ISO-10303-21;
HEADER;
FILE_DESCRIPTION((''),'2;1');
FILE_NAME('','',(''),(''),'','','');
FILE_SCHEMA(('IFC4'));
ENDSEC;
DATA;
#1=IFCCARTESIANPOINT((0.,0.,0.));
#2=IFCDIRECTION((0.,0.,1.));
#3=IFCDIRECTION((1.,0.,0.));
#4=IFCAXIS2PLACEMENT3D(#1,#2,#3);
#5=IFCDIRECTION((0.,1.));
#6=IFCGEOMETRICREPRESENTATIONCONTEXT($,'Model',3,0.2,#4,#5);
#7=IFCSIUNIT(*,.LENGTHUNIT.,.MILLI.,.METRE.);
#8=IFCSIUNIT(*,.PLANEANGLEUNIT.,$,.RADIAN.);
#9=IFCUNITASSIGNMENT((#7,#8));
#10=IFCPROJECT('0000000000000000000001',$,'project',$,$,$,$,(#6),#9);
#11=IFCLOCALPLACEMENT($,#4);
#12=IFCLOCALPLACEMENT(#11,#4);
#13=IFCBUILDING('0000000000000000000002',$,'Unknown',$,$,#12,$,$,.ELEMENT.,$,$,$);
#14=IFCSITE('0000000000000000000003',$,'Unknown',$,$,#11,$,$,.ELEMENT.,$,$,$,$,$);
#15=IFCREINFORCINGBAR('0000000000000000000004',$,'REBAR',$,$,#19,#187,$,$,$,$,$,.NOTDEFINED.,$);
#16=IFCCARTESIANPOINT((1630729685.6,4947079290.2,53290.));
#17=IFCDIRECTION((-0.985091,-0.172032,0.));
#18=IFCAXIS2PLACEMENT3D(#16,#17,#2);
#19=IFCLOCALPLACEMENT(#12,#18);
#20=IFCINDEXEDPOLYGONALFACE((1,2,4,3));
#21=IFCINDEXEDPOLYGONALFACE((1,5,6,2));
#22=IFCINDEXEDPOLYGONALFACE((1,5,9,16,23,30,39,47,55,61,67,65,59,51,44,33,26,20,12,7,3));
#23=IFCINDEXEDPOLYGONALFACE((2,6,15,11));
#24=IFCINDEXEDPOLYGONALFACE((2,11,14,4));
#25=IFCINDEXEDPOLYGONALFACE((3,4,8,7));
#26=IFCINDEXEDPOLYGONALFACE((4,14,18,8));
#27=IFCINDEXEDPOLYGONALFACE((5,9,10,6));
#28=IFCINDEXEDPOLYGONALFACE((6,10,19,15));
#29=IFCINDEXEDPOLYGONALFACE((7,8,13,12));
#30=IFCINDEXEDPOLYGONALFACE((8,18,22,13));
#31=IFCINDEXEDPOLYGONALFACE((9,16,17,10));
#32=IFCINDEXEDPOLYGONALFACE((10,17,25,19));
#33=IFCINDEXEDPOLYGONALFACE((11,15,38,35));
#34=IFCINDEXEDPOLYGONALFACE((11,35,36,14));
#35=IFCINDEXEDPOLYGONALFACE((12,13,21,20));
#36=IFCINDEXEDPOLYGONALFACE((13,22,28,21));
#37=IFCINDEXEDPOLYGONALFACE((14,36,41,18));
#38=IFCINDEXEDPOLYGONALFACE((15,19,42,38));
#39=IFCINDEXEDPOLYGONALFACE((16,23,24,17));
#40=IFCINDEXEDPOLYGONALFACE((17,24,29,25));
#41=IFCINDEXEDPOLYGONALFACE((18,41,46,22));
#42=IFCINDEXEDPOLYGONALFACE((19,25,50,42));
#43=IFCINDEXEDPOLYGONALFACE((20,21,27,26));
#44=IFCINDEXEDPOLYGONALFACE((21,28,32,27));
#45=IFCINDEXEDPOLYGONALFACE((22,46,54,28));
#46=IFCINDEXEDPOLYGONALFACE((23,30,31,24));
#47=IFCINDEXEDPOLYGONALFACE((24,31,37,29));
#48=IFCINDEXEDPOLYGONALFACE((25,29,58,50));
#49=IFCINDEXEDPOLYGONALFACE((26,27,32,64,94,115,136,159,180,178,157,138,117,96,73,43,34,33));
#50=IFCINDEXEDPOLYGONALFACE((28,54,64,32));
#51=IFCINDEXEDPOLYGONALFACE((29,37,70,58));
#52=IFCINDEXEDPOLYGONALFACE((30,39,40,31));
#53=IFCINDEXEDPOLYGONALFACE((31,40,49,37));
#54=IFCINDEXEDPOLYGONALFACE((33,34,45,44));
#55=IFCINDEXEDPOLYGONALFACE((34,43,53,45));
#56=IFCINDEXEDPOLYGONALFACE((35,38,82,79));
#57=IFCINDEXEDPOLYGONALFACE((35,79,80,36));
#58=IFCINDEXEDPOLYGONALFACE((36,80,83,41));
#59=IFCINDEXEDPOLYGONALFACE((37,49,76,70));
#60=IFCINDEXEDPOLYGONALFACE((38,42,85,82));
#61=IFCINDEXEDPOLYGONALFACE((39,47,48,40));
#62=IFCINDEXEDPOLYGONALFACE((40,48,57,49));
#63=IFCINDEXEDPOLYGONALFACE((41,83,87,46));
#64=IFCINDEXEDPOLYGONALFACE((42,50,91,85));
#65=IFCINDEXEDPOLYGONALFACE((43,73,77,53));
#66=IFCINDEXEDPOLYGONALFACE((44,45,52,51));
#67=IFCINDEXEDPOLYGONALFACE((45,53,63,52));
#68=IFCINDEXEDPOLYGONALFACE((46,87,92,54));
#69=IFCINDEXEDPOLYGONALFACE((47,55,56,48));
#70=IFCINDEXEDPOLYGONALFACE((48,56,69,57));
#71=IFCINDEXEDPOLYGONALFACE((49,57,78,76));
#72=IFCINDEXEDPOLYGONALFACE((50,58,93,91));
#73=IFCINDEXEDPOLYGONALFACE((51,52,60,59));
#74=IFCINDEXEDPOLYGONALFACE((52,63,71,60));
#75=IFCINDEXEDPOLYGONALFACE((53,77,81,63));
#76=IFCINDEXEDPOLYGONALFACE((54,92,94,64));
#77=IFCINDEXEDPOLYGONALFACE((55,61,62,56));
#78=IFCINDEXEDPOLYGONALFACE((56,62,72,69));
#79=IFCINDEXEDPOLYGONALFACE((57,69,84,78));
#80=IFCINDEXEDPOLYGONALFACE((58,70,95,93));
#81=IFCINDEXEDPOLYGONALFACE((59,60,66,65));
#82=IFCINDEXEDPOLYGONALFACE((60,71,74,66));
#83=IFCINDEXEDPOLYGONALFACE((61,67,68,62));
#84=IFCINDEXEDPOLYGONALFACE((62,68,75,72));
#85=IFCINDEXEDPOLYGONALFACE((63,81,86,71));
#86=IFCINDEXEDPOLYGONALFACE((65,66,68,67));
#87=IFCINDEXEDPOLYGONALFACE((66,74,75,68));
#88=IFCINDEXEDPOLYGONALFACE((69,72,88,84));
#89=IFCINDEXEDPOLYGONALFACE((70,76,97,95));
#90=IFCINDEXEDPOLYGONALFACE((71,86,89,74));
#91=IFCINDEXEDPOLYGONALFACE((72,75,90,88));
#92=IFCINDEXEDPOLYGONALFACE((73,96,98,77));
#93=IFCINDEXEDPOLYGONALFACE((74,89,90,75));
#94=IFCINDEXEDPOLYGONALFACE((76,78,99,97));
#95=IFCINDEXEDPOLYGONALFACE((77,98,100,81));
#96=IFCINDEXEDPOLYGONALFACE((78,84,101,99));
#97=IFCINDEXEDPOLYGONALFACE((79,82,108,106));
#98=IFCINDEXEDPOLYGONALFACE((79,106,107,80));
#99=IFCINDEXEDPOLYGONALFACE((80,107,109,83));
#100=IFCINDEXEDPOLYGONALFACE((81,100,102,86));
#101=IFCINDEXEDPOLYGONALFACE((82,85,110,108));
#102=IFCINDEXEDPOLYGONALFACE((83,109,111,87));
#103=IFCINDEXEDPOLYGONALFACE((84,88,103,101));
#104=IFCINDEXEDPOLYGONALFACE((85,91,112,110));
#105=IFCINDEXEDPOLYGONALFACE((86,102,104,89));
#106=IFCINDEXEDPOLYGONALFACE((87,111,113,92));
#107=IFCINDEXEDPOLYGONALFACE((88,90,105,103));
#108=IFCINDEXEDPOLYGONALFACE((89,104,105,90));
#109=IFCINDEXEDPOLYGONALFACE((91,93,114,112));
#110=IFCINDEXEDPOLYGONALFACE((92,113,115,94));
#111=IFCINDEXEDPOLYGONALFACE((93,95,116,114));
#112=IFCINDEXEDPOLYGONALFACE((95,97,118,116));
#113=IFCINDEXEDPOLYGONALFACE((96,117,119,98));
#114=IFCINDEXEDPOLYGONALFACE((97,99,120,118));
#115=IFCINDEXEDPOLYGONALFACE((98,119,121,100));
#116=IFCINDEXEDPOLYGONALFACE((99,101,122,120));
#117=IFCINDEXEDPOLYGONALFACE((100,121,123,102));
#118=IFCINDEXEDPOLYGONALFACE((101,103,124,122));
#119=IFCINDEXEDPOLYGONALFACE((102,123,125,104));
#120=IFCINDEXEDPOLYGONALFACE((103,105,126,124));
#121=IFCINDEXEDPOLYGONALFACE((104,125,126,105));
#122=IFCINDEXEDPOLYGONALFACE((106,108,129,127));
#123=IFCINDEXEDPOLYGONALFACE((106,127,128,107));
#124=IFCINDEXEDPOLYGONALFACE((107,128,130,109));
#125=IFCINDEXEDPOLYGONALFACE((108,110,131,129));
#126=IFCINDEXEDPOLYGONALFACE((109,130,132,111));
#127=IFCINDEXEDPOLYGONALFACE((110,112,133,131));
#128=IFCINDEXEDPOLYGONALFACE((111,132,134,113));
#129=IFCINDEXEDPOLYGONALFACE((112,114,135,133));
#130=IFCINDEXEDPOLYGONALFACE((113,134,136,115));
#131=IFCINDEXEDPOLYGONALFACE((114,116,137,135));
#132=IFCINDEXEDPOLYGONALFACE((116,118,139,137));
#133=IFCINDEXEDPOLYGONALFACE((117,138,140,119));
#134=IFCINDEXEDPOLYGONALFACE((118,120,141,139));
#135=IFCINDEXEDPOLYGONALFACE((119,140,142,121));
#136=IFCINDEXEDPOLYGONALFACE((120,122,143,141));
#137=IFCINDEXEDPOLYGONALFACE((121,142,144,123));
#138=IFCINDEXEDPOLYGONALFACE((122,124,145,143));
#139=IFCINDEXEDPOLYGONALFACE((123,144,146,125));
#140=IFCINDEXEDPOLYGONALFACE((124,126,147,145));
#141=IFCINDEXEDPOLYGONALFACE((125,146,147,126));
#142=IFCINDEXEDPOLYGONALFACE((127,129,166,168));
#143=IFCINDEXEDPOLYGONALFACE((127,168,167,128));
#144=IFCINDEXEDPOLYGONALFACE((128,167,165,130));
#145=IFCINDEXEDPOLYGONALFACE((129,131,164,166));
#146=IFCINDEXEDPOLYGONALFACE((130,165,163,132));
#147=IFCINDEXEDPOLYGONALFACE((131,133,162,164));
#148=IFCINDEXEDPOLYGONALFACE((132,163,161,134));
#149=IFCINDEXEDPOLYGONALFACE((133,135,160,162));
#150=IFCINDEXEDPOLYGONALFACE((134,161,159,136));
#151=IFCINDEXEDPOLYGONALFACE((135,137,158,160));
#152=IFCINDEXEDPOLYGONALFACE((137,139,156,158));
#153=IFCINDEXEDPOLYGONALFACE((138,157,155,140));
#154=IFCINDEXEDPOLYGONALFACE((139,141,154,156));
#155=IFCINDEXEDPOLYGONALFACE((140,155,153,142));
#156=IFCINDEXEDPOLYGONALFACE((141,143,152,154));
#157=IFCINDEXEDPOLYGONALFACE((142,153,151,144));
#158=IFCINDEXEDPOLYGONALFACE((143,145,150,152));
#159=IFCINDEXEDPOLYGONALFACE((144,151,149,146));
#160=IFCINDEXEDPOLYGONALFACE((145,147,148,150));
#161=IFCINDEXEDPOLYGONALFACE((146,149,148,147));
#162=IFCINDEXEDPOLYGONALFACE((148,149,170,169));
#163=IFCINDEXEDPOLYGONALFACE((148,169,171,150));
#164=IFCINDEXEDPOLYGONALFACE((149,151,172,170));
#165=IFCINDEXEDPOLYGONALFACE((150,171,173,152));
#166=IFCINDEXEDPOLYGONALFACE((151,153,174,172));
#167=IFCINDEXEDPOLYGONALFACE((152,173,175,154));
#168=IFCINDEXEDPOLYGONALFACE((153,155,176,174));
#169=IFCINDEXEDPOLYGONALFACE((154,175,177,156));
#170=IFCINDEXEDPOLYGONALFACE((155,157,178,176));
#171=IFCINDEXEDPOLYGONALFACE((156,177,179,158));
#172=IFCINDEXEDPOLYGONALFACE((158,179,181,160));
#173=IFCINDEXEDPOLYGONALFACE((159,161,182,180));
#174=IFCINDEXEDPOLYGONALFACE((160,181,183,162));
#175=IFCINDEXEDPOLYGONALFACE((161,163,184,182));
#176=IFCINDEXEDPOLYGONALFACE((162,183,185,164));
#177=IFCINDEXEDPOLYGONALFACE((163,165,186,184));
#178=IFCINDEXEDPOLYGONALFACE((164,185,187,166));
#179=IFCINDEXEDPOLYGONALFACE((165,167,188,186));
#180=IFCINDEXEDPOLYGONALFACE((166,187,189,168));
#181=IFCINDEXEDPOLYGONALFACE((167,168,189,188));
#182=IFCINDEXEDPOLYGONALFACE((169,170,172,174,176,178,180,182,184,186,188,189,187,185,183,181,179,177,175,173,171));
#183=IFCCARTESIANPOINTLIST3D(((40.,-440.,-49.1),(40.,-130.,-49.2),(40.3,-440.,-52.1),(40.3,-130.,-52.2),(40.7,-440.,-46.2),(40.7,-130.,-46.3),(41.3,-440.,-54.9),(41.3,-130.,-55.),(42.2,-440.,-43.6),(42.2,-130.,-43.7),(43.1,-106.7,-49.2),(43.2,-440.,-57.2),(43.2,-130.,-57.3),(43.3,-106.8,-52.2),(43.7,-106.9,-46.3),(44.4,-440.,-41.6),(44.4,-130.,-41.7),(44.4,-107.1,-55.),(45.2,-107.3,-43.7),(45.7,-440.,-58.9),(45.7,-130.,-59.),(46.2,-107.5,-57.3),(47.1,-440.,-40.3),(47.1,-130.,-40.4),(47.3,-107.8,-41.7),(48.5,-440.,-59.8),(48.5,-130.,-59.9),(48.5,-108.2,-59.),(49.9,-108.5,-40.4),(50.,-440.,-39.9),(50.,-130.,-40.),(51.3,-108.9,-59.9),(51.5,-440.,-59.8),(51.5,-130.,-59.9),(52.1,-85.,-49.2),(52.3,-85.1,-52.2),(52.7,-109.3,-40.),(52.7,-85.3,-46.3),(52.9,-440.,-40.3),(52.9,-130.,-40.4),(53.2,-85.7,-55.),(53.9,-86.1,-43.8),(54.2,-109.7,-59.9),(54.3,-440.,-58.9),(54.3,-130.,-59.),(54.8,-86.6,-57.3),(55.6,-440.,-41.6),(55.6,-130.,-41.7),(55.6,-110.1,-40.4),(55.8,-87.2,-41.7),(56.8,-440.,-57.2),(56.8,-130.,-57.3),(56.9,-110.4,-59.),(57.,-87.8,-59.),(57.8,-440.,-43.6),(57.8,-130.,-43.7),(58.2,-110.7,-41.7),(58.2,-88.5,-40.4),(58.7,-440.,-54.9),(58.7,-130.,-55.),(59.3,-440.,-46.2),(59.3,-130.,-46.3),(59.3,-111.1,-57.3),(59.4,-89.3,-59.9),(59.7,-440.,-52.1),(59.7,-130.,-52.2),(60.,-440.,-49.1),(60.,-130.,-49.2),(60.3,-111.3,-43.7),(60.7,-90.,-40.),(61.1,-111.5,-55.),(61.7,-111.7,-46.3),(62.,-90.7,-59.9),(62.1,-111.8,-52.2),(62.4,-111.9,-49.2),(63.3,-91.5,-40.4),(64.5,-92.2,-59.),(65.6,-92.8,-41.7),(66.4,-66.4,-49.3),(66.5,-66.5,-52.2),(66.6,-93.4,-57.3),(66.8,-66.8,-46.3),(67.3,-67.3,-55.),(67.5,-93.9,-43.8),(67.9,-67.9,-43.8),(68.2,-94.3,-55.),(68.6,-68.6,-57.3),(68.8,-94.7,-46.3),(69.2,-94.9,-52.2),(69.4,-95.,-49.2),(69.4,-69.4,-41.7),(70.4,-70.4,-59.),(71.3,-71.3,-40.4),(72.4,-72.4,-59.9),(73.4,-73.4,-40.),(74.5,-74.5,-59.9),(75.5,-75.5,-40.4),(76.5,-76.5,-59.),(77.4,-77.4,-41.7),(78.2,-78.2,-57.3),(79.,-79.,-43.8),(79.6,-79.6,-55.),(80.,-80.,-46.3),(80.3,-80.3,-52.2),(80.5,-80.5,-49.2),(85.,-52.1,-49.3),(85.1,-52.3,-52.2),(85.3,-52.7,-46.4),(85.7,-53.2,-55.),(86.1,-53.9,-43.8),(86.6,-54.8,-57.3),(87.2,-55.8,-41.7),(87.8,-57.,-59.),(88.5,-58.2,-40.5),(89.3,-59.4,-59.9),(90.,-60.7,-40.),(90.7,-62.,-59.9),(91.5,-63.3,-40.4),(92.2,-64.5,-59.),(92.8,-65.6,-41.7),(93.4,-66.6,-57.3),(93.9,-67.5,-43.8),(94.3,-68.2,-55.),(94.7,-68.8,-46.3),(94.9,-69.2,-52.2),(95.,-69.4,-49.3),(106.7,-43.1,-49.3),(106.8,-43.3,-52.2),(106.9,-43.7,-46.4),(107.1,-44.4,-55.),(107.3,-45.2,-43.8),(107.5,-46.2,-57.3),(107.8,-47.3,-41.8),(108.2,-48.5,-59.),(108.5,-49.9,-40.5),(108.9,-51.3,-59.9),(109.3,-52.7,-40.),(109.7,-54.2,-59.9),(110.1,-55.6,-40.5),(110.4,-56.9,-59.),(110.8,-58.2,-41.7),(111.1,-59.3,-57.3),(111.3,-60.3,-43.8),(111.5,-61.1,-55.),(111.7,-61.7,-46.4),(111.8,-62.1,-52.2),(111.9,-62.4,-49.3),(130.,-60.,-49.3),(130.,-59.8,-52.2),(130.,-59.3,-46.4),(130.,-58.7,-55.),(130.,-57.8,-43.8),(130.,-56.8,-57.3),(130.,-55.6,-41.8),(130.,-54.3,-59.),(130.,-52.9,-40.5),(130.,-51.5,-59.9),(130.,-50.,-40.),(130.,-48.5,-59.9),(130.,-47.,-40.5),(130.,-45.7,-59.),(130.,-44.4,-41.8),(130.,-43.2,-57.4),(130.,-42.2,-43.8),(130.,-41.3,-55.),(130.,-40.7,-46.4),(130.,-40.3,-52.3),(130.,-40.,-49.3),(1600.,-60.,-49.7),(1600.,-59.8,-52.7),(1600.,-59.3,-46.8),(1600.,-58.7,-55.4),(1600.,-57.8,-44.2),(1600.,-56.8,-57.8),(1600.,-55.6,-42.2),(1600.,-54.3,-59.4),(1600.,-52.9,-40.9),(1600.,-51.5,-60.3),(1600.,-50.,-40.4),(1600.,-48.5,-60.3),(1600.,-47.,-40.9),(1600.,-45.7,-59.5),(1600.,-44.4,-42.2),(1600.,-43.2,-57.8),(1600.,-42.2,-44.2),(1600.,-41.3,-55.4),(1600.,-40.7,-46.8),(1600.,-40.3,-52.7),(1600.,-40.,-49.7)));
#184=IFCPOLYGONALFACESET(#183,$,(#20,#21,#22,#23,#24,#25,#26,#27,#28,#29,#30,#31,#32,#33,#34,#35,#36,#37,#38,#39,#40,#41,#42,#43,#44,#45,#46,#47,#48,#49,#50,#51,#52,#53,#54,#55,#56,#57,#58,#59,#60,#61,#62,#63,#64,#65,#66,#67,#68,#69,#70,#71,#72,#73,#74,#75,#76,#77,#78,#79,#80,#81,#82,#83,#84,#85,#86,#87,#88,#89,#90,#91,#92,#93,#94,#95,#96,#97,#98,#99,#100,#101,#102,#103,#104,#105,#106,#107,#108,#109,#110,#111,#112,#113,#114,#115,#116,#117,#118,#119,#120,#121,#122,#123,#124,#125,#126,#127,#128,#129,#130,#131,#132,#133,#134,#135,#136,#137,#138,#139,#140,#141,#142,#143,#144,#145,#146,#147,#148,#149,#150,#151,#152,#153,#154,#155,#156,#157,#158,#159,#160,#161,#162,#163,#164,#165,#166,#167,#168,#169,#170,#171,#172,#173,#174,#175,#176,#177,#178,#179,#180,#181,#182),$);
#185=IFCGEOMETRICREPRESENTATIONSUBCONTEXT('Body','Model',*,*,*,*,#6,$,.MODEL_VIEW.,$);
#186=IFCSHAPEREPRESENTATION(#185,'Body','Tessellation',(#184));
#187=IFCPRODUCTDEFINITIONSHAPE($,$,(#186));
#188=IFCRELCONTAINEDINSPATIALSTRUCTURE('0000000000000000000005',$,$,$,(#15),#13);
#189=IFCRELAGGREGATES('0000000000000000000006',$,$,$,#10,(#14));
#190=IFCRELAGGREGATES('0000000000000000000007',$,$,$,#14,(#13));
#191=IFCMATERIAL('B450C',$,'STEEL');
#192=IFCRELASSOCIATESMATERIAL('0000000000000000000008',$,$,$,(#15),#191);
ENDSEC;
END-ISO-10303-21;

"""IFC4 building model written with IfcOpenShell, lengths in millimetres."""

from ifc_helpers import new_model, entity, si_unit, direction, frame, origin_with_axes, place, context, subcontext, project, spatial, material, element, save


model = new_model("IFC4")

# Units and contexts
model_context = context("Model", 3, precision=0.2, world=origin_with_axes(), true_north=direction((0.0, 1.0)))
body_context = subcontext(model_context, "Body", "Model", "MODEL_VIEW")
ifc_project = project(units=[si_unit("LENGTHUNIT", "METRE", prefix="MILLI"), si_unit("PLANEANGLEUNIT", "RADIAN")], contexts=[model_context])

# Site, building
site_placement = place(None, origin_with_axes())
site = spatial("IfcSite", under=ifc_project, at=site_placement, Name="Unknown", CompositionType="ELEMENT")
building_placement = place(site_placement, origin_with_axes())
building = spatial("IfcBuilding", under=site, at=building_placement, Name="Unknown", CompositionType="ELEMENT")

# Reinforcing bar
ifc_material = material(Name="B450C", Category="STEEL")
reinforcing_bar_1_placement = place(building_placement, frame((1630729685.6, 4947079290.2, 53290.0), z_axis=(-0.985091, -0.172032, 0.0), x_axis=(0.0, 0.0, 1.0)))
element("IfcReinforcingBar", 1, at=reinforcing_bar_1_placement, inside=building, material=ifc_material, Name="REBAR", PredefinedType="NOTDEFINED", context=body_context, shape_type="AdvancedSweptSolid", body=[
    entity("IfcSweptDiskSolid", entity("IfcIndexedPolyCurve", entity("IfcCartesianPointList3D", [[50.0, -440.0, -49.9], [50.0, -130.0, -50.0], [73.4, -73.4, -50.0], [130.0, -50.0, -50.0], [1600.0, -50.0, -50.4]]), [entity("IfcLineIndex", [1, 2]), entity("IfcArcIndex", [2, 3, 4]), entity("IfcLineIndex", [4, 5])]), 10.0),
])

save(model, "model.ifc")
